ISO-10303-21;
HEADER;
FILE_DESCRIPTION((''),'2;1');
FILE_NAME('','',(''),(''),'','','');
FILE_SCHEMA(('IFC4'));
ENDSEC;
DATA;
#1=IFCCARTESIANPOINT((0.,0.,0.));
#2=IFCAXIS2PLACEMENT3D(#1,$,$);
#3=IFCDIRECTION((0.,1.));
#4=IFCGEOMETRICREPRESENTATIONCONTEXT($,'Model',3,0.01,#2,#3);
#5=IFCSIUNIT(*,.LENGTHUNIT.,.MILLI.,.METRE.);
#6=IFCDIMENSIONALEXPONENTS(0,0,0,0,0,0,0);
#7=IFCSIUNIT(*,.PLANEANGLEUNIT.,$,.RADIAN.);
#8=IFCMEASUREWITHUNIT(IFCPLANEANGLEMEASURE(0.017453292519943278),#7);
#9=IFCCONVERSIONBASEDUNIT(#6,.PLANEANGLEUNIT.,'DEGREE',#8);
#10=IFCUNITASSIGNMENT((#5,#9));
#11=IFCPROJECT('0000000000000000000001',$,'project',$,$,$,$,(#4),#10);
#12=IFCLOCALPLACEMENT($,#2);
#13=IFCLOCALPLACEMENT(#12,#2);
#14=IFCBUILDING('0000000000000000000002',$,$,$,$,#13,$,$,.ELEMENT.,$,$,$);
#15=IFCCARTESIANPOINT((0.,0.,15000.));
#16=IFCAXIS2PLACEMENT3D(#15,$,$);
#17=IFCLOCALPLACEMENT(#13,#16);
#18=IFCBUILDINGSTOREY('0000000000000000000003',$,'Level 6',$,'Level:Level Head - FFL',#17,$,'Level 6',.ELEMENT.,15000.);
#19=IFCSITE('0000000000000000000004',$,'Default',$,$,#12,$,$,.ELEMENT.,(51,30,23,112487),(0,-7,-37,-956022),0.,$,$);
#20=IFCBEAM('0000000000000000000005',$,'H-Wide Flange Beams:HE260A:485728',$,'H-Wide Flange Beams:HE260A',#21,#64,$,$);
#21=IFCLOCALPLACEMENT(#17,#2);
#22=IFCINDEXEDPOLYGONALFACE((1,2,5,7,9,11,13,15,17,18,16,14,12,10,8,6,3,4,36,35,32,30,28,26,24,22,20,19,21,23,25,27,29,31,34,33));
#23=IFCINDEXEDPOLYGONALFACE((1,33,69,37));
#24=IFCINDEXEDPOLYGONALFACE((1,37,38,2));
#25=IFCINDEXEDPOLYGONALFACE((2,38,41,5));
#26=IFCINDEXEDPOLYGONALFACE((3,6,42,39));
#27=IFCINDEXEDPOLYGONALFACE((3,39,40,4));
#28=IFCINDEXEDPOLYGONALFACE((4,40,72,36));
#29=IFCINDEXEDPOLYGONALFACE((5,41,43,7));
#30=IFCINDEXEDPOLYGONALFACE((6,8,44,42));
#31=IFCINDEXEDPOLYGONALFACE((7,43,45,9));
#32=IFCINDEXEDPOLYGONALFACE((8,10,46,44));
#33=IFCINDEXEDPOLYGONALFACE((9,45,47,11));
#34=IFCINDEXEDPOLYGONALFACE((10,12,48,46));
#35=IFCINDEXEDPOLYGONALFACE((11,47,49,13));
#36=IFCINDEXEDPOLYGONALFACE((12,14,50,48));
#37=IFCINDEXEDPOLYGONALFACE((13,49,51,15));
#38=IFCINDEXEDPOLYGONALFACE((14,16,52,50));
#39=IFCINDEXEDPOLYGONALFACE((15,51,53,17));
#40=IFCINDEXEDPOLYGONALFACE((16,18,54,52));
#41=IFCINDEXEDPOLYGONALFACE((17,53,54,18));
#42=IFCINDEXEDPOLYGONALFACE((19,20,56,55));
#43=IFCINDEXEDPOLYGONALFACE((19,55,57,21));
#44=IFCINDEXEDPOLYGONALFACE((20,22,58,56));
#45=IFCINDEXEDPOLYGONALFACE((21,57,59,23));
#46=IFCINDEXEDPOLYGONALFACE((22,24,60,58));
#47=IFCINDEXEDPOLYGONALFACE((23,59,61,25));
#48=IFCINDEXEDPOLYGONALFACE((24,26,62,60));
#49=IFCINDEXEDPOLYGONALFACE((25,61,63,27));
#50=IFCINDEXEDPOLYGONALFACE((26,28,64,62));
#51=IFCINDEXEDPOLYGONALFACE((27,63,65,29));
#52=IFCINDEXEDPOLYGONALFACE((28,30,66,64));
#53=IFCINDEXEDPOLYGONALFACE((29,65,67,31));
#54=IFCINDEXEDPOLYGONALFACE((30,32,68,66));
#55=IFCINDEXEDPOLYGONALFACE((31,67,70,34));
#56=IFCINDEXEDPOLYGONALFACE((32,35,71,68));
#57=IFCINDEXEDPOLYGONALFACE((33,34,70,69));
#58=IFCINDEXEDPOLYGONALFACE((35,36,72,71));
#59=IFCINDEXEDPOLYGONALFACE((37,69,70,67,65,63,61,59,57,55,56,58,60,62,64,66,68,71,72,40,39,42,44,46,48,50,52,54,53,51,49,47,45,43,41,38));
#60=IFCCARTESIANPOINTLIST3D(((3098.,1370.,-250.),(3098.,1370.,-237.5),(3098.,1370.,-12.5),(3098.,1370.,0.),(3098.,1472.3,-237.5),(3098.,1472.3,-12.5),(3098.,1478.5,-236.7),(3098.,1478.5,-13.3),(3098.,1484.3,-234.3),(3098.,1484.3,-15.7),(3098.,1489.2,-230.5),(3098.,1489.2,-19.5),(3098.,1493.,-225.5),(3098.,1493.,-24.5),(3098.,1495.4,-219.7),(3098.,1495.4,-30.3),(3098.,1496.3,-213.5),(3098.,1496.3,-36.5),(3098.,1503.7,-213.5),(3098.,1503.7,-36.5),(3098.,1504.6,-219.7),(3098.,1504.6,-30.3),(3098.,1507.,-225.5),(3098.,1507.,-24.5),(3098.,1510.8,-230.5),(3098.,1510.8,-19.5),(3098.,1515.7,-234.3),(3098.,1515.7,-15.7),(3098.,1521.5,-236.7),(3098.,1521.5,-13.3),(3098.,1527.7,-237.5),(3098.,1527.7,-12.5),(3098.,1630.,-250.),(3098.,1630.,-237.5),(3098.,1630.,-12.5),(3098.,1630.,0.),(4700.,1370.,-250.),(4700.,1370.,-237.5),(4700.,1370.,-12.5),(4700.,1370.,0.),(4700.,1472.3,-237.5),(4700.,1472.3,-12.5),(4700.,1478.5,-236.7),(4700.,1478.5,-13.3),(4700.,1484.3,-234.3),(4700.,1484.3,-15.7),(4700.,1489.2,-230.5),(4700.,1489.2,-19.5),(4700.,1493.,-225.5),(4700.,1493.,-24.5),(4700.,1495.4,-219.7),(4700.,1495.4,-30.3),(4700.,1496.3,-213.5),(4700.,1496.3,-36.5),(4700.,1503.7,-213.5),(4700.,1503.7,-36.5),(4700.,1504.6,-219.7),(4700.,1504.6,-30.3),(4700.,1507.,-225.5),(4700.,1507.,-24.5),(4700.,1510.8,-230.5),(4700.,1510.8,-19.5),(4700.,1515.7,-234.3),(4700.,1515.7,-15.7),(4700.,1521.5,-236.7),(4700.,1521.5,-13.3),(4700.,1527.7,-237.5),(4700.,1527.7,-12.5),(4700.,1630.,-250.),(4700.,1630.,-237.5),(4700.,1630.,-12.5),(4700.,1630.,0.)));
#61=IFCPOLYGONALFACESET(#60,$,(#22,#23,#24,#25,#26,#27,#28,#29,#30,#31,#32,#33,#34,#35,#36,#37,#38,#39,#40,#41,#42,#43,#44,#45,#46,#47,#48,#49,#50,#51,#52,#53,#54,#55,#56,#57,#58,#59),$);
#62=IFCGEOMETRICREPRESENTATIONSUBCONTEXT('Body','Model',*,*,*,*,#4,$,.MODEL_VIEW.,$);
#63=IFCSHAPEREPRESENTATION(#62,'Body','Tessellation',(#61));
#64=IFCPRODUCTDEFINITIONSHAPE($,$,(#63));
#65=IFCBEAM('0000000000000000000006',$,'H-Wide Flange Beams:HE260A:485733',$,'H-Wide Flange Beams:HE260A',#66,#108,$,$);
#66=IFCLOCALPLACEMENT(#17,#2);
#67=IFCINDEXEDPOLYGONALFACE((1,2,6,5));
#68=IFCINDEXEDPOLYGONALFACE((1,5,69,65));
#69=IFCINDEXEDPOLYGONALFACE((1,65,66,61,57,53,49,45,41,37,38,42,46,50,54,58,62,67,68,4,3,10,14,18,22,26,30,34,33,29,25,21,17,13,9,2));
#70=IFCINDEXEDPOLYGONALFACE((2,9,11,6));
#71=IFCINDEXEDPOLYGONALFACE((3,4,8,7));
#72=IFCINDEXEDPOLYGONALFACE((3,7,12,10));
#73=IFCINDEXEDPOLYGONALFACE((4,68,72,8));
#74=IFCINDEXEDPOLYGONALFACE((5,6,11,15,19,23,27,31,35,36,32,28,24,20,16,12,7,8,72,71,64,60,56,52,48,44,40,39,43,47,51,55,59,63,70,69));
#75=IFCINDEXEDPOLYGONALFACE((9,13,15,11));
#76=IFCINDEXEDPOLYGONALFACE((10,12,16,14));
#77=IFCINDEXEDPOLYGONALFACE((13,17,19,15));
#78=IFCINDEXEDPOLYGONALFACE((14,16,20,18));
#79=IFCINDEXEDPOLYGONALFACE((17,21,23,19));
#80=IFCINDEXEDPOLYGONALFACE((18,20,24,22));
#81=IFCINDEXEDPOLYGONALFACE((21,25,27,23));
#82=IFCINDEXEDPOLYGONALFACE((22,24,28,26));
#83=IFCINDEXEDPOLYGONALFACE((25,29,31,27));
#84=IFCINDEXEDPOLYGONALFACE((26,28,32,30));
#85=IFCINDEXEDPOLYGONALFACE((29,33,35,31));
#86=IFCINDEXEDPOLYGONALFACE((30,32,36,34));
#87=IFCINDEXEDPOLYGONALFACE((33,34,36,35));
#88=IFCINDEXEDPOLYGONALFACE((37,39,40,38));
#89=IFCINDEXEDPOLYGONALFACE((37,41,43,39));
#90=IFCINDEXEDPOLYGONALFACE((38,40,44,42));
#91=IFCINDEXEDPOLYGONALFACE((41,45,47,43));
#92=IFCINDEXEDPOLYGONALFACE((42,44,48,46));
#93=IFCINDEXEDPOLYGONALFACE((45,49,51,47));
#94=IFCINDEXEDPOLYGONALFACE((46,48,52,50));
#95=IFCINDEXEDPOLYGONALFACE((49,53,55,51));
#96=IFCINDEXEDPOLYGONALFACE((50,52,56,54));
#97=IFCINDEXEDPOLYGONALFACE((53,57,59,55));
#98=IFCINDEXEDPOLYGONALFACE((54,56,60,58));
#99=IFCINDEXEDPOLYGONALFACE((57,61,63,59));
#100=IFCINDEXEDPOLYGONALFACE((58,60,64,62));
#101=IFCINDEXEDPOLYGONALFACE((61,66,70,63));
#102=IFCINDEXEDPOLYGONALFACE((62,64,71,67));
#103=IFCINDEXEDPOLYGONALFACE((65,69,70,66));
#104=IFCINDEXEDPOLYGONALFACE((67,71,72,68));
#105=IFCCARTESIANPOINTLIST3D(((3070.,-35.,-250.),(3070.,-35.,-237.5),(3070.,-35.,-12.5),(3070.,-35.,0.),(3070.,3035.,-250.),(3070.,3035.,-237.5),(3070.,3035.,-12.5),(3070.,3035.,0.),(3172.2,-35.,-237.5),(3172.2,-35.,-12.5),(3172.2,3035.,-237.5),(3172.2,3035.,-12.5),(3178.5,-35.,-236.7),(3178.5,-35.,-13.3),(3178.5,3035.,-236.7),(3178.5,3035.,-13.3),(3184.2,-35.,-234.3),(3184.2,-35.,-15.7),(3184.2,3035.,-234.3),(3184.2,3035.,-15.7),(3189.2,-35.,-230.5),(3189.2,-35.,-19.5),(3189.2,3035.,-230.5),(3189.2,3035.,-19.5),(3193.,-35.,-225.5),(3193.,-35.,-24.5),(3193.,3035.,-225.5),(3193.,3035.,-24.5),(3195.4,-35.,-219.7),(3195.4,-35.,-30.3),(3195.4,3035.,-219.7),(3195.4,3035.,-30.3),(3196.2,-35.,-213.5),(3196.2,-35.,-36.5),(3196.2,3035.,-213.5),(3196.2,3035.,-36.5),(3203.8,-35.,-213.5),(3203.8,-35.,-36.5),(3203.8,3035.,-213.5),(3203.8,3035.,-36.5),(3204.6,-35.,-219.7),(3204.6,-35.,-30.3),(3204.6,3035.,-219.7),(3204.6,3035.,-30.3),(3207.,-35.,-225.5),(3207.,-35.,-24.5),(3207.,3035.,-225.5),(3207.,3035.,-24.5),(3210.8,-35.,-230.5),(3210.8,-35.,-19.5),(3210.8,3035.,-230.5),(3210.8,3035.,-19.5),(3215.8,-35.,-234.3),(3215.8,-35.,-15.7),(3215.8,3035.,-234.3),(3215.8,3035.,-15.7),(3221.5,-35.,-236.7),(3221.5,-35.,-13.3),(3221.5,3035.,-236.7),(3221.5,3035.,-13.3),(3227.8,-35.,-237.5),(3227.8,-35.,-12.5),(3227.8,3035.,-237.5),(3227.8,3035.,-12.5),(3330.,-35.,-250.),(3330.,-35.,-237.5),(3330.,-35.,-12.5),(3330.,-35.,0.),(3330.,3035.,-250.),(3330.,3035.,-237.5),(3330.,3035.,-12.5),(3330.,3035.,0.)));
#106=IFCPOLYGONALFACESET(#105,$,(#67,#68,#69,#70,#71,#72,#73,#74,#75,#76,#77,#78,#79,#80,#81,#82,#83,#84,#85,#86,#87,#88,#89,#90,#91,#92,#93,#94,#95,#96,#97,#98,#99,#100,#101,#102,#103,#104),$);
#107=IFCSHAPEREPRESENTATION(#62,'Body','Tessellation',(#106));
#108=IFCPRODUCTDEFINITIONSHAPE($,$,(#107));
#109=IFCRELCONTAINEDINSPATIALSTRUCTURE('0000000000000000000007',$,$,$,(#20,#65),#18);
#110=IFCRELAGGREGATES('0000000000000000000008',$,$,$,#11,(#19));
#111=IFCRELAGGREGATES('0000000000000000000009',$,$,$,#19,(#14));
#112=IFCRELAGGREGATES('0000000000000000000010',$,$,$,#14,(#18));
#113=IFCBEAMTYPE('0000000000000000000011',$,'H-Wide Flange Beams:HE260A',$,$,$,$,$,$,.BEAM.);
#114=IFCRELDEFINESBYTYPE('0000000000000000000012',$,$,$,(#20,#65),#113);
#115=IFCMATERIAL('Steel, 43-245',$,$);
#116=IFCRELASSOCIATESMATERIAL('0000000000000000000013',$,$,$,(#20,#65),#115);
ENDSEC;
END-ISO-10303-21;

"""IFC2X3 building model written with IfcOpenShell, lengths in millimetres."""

from ifc_helpers import new_model, entity, si_unit, converted_unit, direction, frame, frame_2d, origin, place, context, subcontext, project, spatial, i_section, extrude, material, type_object, element, save


model = new_model("IFC2X3")

# Units and contexts
model_context = context("Model", 3, precision=0.01, world=origin(), true_north=direction((0.0, 1.0)))
body_context = subcontext(model_context, "Body", "Model", "MODEL_VIEW")
ifc_project = project(units=[si_unit("LENGTHUNIT", "METRE", prefix="MILLI"), converted_unit("PLANEANGLEUNIT", "DEGREE", entity("IfcPlaneAngleMeasure", 0.017453292519943278), si_unit("PLANEANGLEUNIT", "RADIAN"), dimensions=[0, 0, 0, 0, 0, 0, 0])], contexts=[model_context])

# Site, building, storey
site_placement = place(None, origin())
site = spatial("IfcSite", under=ifc_project, at=site_placement, Name="Default", CompositionType="ELEMENT", RefLatitude=(51, 30, 23, 112487), RefLongitude=(0, -7, -37, -956022), RefElevation=0.0)
building_placement = place(site_placement, origin())
building = spatial("IfcBuilding", under=site, at=building_placement, CompositionType="ELEMENT")
storey_placement = place(building_placement, frame((0.0, 0.0, 15000.0)))
storey = spatial("IfcBuildingStorey", under=building, at=storey_placement, Name="Level 6", ObjectType="Level:Level Head - FFL", LongName="Level 6", CompositionType="ELEMENT", Elevation=15000.0)

# Beams
ifc_material = material(Name="Steel, 43-245")
beam_type_1 = type_object("IfcBeamType", Name="H-Wide Flange Beams:HE260A", PredefinedType="BEAM")
beam_1_placement = place(storey_placement, frame((4700.0, 1500.0, 0.0), z_axis=(0.0, 0.0, 1.0), x_axis=(-1.0, 0.0, 0.0)))
element("IfcBeam", 1, at=beam_1_placement, inside=storey, type_object=beam_type_1, material=ifc_material, Name="H-Wide Flange Beams:HE260A:485728", ObjectType="H-Wide Flange Beams:HE260A", context=body_context, shape_type="SweptSolid", body=[
    extrude(i_section(OverallWidth=260.0, OverallDepth=250.0, WebThickness=7.5, FlangeThickness=12.5, FilletRadius=24.0, at=frame_2d((0.0, 0.0), x_axis=(0.0, 1.0))), frame((0.0, 0.0, -125.0), z_axis=(1.0, 0.0, 0.0), x_axis=(0.0, 0.0, -1.0)), (0.0, 0.0, 1.0), 1602.0),
])
beam_2_placement = place(storey_placement, frame((3200.0, 0.0, 0.0), z_axis=(0.0, 0.0, 1.0), x_axis=(0.0, 1.0, 0.0)))
element("IfcBeam", 2, at=beam_2_placement, inside=storey, type_object=beam_type_1, material=ifc_material, Name="H-Wide Flange Beams:HE260A:485733", ObjectType="H-Wide Flange Beams:HE260A", context=body_context, shape_type="SweptSolid", body=[
    extrude(i_section(OverallWidth=260.0, OverallDepth=250.0, WebThickness=7.5, FlangeThickness=12.5, FilletRadius=24.0, at=frame_2d((0.0, 0.0), x_axis=(0.0, 1.0))), frame((-35.0, 0.0, -125.0), z_axis=(1.0, 0.0, 0.0), x_axis=(0.0, 0.0, -1.0)), (0.0, 0.0, 1.0), 3070.0),
])

save(model, "model.ifc")
